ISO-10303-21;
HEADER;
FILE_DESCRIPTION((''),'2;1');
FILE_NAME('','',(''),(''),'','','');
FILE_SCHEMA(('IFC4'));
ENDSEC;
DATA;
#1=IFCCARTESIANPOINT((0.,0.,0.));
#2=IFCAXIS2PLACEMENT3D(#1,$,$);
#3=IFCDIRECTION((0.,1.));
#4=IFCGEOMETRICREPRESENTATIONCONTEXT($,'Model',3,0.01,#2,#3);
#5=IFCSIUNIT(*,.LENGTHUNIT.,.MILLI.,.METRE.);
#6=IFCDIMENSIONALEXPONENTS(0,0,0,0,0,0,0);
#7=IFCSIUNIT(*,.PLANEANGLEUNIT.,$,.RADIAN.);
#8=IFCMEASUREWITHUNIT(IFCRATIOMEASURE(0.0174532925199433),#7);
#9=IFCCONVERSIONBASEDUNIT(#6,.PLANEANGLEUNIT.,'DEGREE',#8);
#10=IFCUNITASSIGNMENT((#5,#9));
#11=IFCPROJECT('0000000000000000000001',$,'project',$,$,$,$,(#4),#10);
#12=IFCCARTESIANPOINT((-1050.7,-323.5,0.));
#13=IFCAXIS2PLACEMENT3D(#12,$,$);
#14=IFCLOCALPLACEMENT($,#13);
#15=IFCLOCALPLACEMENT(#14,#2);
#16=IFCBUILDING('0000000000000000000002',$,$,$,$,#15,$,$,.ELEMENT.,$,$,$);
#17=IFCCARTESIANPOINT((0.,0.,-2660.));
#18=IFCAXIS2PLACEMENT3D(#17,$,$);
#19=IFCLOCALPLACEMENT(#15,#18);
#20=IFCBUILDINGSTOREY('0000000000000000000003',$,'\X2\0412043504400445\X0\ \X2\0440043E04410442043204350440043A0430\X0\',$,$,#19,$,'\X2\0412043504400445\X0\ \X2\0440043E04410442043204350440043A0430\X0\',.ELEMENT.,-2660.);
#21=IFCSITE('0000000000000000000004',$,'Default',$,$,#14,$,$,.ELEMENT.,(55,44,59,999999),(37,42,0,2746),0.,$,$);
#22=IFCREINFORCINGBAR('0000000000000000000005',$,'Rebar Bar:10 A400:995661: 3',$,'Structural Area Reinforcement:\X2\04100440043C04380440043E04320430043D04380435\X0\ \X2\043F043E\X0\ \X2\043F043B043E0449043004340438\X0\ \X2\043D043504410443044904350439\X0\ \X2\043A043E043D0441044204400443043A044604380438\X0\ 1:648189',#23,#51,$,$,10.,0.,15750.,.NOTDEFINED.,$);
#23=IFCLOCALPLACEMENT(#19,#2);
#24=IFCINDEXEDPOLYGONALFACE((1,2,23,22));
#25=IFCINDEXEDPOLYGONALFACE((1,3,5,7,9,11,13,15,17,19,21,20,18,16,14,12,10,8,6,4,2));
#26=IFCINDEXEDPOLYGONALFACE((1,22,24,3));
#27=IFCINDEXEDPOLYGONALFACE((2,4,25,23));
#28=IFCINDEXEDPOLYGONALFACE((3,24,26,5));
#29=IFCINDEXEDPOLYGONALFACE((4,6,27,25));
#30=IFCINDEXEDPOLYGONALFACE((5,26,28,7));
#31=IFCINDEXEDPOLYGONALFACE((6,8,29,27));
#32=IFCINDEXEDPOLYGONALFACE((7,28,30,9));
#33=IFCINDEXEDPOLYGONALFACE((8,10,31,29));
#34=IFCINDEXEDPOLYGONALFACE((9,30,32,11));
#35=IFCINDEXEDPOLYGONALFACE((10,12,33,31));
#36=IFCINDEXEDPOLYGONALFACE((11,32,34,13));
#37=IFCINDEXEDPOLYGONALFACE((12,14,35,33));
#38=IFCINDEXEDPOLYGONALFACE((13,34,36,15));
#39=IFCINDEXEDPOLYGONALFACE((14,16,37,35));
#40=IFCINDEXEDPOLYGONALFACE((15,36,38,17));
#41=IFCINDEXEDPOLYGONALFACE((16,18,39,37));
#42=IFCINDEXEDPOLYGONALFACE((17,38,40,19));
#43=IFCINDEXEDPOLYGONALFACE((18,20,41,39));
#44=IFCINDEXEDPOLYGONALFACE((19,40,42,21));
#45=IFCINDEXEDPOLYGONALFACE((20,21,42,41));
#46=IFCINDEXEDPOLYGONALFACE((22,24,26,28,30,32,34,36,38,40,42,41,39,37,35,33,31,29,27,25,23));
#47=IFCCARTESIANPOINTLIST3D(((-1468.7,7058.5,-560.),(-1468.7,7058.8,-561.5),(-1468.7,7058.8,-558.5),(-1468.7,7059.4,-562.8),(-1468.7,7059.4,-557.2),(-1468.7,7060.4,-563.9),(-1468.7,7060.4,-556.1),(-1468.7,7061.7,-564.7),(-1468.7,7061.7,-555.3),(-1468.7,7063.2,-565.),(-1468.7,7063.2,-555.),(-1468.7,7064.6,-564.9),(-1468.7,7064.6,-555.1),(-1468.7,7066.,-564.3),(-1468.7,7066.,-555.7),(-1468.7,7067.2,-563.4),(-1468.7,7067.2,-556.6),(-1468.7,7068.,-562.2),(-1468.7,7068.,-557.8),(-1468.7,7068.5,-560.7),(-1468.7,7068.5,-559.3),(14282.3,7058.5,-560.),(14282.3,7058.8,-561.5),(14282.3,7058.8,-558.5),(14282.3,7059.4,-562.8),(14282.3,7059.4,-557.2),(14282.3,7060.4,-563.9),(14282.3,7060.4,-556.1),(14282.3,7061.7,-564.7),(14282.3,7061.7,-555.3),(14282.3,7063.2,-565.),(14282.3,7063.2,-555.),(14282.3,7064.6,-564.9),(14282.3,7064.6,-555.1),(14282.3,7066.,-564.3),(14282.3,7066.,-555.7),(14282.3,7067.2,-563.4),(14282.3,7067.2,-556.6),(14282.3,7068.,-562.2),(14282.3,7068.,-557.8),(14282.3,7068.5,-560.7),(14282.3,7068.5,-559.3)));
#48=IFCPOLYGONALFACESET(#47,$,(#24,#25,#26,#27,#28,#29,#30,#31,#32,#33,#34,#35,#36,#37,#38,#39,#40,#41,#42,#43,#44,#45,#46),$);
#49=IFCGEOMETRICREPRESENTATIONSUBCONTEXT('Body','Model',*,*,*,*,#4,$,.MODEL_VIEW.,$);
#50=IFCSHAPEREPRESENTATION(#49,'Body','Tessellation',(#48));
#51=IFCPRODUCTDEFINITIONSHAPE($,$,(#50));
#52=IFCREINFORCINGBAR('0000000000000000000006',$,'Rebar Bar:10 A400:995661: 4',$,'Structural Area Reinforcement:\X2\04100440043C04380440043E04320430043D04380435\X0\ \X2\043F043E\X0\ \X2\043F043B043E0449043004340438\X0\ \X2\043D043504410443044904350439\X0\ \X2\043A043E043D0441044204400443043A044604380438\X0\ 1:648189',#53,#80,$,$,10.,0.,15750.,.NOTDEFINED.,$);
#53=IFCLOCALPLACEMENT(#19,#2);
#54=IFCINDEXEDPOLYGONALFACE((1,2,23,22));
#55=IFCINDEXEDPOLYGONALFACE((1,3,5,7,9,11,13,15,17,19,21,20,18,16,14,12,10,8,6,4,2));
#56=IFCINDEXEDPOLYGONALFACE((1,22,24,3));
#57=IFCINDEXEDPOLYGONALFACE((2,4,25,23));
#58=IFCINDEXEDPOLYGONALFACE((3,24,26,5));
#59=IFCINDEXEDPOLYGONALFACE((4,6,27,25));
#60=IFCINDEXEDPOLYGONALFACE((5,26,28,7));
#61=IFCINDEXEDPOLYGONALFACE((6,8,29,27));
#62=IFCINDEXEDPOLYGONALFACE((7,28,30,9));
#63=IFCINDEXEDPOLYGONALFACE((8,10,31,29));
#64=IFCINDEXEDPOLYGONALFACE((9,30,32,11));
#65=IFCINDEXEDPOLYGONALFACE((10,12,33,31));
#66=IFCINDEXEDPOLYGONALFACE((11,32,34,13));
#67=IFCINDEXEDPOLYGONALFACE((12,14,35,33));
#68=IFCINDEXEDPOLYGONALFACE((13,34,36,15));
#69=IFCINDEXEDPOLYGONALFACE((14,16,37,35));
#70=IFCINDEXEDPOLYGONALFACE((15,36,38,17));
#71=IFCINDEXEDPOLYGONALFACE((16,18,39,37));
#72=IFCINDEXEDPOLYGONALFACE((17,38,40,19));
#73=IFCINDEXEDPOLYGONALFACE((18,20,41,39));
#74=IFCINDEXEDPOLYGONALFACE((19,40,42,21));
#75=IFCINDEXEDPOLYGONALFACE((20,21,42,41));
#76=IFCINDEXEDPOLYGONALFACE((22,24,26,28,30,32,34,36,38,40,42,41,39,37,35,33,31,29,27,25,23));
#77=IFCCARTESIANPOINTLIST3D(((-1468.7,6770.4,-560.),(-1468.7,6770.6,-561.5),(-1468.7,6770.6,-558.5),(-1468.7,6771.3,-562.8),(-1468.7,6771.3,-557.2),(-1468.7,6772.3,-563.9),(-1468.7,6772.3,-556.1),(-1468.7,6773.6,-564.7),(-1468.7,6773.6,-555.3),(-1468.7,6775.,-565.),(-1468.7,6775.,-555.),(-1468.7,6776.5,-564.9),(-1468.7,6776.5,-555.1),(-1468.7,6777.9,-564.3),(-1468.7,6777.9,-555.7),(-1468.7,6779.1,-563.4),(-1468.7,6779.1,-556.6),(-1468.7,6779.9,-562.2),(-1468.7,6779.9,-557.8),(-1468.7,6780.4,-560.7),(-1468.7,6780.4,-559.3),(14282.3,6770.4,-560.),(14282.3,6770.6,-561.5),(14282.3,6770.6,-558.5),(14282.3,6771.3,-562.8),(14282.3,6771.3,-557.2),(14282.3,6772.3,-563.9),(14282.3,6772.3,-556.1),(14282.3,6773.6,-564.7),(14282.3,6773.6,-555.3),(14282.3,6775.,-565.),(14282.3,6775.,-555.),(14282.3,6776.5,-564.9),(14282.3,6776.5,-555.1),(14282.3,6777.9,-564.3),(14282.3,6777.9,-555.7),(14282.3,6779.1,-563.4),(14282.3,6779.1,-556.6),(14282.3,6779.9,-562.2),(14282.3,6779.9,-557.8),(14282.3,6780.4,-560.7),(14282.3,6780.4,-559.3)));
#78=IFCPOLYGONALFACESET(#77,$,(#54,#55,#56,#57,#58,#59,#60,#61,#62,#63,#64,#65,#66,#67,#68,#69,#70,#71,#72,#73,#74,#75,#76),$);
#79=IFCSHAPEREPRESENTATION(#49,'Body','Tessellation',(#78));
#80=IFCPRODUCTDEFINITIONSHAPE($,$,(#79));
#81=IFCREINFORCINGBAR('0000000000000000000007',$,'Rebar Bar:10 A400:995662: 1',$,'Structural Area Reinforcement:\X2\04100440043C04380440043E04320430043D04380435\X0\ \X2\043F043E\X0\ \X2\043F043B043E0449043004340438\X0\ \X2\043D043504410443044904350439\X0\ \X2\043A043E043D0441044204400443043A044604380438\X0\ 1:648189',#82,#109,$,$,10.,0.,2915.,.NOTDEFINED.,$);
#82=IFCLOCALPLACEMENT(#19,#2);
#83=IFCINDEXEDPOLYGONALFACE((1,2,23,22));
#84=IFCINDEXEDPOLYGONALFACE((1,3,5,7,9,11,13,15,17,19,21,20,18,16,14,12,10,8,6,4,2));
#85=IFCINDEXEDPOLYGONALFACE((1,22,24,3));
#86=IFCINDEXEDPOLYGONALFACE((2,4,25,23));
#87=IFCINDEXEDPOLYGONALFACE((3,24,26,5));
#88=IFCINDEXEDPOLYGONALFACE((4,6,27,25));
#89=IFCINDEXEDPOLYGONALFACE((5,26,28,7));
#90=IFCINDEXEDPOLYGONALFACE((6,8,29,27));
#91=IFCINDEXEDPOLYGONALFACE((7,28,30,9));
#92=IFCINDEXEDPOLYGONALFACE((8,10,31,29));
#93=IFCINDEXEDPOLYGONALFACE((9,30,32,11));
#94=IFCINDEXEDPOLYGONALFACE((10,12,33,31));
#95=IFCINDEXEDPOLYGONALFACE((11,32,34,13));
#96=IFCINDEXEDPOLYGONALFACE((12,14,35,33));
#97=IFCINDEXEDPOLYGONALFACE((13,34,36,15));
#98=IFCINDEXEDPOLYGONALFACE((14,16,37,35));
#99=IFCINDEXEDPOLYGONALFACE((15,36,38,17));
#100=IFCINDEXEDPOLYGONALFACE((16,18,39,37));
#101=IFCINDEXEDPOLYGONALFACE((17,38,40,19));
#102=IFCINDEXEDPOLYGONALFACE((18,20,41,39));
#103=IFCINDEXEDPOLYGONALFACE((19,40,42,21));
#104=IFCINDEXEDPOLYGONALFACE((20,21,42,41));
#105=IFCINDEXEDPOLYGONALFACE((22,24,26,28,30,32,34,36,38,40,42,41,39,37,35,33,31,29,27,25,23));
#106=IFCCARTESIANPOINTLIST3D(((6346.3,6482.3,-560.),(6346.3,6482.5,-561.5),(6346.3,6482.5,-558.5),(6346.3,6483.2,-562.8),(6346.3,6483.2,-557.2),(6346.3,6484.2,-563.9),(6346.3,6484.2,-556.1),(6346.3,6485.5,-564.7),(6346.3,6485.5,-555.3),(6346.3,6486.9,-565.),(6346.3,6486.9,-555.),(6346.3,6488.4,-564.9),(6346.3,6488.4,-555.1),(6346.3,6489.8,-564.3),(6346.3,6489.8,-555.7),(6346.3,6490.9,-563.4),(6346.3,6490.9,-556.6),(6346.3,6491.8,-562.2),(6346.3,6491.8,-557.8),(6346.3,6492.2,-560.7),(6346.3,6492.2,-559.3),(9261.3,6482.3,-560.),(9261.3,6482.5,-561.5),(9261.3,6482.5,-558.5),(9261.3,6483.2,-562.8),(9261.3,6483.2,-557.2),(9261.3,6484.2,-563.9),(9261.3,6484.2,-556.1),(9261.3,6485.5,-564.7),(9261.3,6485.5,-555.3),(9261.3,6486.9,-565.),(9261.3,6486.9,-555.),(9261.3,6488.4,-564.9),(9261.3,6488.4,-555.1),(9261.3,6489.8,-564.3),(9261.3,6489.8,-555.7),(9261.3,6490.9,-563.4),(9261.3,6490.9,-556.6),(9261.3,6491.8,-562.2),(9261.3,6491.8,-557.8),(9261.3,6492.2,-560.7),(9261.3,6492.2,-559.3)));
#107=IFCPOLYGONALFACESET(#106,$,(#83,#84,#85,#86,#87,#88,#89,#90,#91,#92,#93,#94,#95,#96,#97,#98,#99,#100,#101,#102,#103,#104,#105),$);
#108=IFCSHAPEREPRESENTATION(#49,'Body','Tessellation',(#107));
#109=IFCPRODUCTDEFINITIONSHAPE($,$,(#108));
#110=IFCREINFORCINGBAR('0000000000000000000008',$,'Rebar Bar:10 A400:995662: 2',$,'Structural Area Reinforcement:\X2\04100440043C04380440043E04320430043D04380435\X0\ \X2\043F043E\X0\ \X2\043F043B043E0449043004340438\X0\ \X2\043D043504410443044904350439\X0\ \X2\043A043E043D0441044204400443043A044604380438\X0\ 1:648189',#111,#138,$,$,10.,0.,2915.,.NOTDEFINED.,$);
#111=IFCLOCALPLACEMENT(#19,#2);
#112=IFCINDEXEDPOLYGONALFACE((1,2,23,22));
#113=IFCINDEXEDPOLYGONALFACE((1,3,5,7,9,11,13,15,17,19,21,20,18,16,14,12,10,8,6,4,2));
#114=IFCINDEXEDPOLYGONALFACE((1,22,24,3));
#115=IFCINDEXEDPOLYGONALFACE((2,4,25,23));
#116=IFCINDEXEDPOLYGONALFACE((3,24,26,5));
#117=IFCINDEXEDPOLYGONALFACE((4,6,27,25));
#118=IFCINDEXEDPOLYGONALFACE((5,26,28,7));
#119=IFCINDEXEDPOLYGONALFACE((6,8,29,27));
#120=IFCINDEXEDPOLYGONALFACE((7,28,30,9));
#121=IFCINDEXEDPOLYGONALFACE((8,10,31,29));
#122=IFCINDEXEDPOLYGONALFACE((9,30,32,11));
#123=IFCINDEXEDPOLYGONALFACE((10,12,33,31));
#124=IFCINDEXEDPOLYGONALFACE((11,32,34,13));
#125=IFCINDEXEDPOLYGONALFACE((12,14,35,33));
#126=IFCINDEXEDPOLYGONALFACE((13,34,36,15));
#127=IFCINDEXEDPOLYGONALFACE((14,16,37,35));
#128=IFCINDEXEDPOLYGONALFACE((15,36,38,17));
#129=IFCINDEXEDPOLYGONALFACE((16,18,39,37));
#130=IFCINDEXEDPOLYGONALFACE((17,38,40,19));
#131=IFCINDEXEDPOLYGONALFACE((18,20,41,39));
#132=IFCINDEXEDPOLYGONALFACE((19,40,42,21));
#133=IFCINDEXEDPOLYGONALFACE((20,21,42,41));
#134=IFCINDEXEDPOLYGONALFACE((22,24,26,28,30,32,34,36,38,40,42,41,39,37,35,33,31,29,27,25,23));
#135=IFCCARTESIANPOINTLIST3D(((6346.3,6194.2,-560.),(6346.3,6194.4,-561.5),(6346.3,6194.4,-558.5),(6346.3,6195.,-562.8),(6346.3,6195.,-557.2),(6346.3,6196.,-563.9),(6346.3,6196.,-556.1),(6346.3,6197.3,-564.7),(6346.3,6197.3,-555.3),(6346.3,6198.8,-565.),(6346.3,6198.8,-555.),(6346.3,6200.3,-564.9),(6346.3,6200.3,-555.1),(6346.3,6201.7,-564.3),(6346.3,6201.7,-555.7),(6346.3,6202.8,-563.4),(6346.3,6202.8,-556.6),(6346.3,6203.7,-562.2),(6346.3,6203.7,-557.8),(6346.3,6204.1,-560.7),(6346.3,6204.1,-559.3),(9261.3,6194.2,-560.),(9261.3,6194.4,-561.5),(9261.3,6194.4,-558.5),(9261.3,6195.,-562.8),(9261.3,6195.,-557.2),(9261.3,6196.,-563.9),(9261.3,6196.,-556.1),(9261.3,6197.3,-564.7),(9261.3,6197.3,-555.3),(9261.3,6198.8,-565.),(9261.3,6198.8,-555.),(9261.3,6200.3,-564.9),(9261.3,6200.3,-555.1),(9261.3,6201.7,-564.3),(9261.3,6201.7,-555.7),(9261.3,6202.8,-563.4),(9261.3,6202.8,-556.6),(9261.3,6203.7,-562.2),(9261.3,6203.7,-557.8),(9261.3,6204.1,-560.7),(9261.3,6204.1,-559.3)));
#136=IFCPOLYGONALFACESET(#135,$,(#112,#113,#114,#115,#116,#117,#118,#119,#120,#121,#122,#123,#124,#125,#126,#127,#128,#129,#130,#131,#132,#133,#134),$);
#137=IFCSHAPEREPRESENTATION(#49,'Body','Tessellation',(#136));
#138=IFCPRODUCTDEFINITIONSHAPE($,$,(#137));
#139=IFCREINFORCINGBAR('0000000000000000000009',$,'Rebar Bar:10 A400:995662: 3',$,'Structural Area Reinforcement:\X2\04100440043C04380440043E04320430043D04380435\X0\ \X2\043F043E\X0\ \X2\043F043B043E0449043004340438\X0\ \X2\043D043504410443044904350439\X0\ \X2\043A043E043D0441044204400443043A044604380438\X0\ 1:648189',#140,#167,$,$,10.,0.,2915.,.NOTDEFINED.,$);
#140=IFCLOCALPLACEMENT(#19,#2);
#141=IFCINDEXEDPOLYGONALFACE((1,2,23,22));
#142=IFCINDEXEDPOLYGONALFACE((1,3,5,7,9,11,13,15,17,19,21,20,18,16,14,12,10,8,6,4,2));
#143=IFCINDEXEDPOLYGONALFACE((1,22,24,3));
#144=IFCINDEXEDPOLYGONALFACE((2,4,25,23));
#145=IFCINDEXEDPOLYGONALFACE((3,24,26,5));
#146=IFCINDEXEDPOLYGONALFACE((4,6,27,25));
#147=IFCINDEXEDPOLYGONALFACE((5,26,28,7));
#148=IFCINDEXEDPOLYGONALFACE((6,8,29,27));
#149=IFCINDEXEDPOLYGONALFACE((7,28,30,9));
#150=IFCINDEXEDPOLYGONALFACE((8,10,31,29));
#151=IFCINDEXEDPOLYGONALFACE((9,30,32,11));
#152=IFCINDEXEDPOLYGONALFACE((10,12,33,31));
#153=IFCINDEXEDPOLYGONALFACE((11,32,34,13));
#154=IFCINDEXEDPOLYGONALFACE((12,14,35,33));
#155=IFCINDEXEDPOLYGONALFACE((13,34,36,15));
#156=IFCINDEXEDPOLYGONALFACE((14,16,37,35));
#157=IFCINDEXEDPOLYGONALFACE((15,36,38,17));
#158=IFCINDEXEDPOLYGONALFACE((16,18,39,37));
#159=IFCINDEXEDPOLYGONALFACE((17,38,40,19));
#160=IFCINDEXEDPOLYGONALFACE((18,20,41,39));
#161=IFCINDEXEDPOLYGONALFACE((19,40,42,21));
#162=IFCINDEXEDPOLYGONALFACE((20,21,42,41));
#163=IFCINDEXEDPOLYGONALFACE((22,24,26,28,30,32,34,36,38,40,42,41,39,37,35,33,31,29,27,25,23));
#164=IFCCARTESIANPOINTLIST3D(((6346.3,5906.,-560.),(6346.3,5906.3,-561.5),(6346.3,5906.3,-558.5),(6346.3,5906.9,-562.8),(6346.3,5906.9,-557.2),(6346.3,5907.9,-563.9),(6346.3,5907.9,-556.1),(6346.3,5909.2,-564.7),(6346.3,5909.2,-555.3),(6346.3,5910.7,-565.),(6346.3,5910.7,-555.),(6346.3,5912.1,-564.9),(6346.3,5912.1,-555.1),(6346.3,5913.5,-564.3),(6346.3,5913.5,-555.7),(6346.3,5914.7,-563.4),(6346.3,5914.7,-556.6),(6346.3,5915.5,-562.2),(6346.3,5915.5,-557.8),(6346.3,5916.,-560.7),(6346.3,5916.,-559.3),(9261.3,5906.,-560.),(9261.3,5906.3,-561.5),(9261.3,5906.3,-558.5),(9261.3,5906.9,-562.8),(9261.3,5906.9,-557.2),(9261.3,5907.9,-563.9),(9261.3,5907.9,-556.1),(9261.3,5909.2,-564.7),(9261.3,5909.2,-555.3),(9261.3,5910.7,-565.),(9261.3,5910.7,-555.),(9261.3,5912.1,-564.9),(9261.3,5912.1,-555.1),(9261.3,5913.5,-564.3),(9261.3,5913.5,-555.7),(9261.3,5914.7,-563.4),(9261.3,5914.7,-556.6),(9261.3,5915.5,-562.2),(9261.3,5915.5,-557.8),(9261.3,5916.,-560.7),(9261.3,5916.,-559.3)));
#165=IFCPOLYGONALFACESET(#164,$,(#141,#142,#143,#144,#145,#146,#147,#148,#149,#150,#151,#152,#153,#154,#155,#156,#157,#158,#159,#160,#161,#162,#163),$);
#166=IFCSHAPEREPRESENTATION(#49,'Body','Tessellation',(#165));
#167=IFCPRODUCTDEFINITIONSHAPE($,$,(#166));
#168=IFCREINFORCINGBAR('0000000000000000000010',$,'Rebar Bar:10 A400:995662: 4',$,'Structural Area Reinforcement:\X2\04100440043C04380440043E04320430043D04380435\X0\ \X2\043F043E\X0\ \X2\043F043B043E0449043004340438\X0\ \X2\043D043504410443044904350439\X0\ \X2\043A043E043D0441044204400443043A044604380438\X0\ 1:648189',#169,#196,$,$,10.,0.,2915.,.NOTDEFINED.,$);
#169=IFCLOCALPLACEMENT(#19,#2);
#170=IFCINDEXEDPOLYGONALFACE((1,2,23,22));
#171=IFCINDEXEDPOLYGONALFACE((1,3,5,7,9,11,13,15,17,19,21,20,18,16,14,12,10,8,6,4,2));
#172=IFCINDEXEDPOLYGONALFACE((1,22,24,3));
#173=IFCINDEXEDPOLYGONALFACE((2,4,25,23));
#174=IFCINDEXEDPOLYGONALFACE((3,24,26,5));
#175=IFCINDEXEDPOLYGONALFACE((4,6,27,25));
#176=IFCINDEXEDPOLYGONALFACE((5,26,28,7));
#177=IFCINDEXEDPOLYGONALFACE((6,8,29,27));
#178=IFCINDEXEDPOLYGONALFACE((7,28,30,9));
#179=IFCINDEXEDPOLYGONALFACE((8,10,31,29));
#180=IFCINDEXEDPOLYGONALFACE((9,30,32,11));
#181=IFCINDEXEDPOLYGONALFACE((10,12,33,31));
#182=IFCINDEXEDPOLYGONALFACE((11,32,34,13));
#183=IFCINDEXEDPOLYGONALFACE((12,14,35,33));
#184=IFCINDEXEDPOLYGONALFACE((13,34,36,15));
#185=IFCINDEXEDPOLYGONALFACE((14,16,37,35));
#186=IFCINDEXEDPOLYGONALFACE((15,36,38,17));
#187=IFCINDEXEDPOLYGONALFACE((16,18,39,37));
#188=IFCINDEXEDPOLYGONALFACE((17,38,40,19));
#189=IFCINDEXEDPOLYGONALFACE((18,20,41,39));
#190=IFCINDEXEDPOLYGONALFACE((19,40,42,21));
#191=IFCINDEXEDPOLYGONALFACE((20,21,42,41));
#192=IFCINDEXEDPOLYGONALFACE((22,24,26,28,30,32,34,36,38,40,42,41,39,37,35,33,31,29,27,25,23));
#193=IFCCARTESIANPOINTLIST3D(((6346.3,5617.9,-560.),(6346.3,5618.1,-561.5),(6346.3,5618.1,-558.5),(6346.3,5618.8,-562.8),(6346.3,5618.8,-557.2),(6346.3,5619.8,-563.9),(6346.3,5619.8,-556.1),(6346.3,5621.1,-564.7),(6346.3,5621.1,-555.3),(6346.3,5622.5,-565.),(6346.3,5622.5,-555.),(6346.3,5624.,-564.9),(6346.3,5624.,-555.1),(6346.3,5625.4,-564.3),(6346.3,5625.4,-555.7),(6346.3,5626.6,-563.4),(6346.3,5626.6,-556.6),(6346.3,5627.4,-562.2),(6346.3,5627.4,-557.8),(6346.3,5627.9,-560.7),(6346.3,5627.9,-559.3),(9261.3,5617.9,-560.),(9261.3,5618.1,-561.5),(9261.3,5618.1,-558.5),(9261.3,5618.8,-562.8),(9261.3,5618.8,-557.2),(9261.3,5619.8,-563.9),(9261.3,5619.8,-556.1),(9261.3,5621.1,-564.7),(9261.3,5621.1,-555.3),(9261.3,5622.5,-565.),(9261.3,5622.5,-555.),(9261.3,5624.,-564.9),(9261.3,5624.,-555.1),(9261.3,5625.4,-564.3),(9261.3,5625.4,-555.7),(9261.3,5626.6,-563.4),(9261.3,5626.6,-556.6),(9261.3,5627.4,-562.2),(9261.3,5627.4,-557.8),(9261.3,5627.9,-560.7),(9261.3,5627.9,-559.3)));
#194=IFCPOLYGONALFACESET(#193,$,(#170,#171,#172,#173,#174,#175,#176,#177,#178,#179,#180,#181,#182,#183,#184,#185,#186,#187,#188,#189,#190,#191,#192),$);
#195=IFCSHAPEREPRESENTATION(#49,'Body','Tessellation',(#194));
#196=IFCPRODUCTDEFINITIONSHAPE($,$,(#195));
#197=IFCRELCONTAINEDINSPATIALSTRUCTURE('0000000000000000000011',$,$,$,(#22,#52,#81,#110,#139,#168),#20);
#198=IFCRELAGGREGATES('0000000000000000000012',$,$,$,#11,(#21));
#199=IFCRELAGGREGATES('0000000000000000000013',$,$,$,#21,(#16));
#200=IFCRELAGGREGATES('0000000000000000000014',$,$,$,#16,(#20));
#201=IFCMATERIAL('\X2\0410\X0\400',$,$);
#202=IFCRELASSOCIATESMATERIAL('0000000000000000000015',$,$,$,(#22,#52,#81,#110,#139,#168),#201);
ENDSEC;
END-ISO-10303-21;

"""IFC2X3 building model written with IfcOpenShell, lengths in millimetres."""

from ifc_helpers import new_model, entity, si_unit, converted_unit, direction, frame, origin, place, context, subcontext, project, spatial, material, element, save


model = new_model("IFC2X3")

# Units and contexts
model_context = context("Model", 3, precision=0.01, world=origin(), true_north=direction((0.0, 1.0)))
body_context = subcontext(model_context, "Body", "Model", "MODEL_VIEW")
ifc_project = project(units=[si_unit("LENGTHUNIT", "METRE", prefix="MILLI"), converted_unit("PLANEANGLEUNIT", "DEGREE", entity("IfcRatioMeasure", 0.0174532925199433), si_unit("PLANEANGLEUNIT", "RADIAN"), dimensions=[0, 0, 0, 0, 0, 0, 0])], contexts=[model_context])

# Site, building, storey
site_placement = place(None, frame((-1050.7, -323.5, 0.0)))
site = spatial("IfcSite", under=ifc_project, at=site_placement, Name="Default", CompositionType="ELEMENT", RefLatitude=(55, 44, 59, 999999), RefLongitude=(37, 42, 0, 2746), RefElevation=0.0)
building_placement = place(site_placement, origin())
building = spatial("IfcBuilding", under=site, at=building_placement, CompositionType="ELEMENT")
storey_placement = place(building_placement, frame((0.0, 0.0, -2660.0)))
storey = spatial("IfcBuildingStorey", under=building, at=storey_placement, Name="Верх ростверка", LongName="Верх ростверка", CompositionType="ELEMENT", Elevation=-2660.0)

# Reinforcing bars
ifc_material = material(Name="А400")
reinforcing_bar_1_placement = place(storey_placement, origin())
element("IfcReinforcingBar", 1, at=reinforcing_bar_1_placement, inside=storey, material=ifc_material, Name="Rebar Bar:10 A400:995661: 3", ObjectType="Structural Area Reinforcement:Армирование по площади несущей конструкции 1:648189", BarLength=15750.0, BarRole="NOTDEFINED", CrossSectionArea=0.0, NominalDiameter=10.0, context=body_context, shape_type="AdvancedSweptSolid", body=[
    entity("IfcSweptDiskSolid", entity("IfcCompositeCurve", [entity("IfcCompositeCurveSegment", "CONTINUOUS", True, entity("IfcPolyline", [entity("IfcCartesianPoint", [14282.3, 7063.5, -560.0]), entity("IfcCartesianPoint", [-1468.7, 7063.5, -560.0])]))], False), 5.0, None, 0.0, 1.0),
])
reinforcing_bar_2_placement = place(storey_placement, origin())
element("IfcReinforcingBar", 2, at=reinforcing_bar_2_placement, inside=storey, material=ifc_material, Name="Rebar Bar:10 A400:995661: 4", ObjectType="Structural Area Reinforcement:Армирование по площади несущей конструкции 1:648189", BarLength=15750.0, BarRole="NOTDEFINED", CrossSectionArea=0.0, NominalDiameter=10.0, context=body_context, shape_type="AdvancedSweptSolid", body=[
    entity("IfcSweptDiskSolid", entity("IfcCompositeCurve", [entity("IfcCompositeCurveSegment", "CONTINUOUS", True, entity("IfcPolyline", [entity("IfcCartesianPoint", [14282.3, 6775.4, -560.0]), entity("IfcCartesianPoint", [-1468.7, 6775.4, -560.0])]))], False), 5.0, None, 0.0, 1.0),
])
reinforcing_bar_3_placement = place(storey_placement, origin())
element("IfcReinforcingBar", 3, at=reinforcing_bar_3_placement, inside=storey, material=ifc_material, Name="Rebar Bar:10 A400:995662: 1", ObjectType="Structural Area Reinforcement:Армирование по площади несущей конструкции 1:648189", BarLength=2915.0, BarRole="NOTDEFINED", CrossSectionArea=0.0, NominalDiameter=10.0, context=body_context, shape_type="AdvancedSweptSolid", body=[
    entity("IfcSweptDiskSolid", entity("IfcCompositeCurve", [entity("IfcCompositeCurveSegment", "CONTINUOUS", True, entity("IfcPolyline", [entity("IfcCartesianPoint", [9261.3, 6487.3, -560.0]), entity("IfcCartesianPoint", [6346.3, 6487.3, -560.0])]))], False), 5.0, None, 0.0, 1.0),
])
reinforcing_bar_4_placement = place(storey_placement, origin())
element("IfcReinforcingBar", 4, at=reinforcing_bar_4_placement, inside=storey, material=ifc_material, Name="Rebar Bar:10 A400:995662: 2", ObjectType="Structural Area Reinforcement:Армирование по площади несущей конструкции 1:648189", BarLength=2915.0, BarRole="NOTDEFINED", CrossSectionArea=0.0, NominalDiameter=10.0, context=body_context, shape_type="AdvancedSweptSolid", body=[
    entity("IfcSweptDiskSolid", entity("IfcCompositeCurve", [entity("IfcCompositeCurveSegment", "CONTINUOUS", True, entity("IfcPolyline", [entity("IfcCartesianPoint", [9261.3, 6199.2, -560.0]), entity("IfcCartesianPoint", [6346.3, 6199.2, -560.0])]))], False), 5.0, None, 0.0, 1.0),
])
reinforcing_bar_5_placement = place(storey_placement, origin())
element("IfcReinforcingBar", 5, at=reinforcing_bar_5_placement, inside=storey, material=ifc_material, Name="Rebar Bar:10 A400:995662: 3", ObjectType="Structural Area Reinforcement:Армирование по площади несущей конструкции 1:648189", BarLength=2915.0, BarRole="NOTDEFINED", CrossSectionArea=0.0, NominalDiameter=10.0, context=body_context, shape_type="AdvancedSweptSolid", body=[
    entity("IfcSweptDiskSolid", entity("IfcCompositeCurve", [entity("IfcCompositeCurveSegment", "CONTINUOUS", True, entity("IfcPolyline", [entity("IfcCartesianPoint", [9261.3, 5911.0, -560.0]), entity("IfcCartesianPoint", [6346.3, 5911.0, -560.0])]))], False), 5.0, None, 0.0, 1.0),
])
reinforcing_bar_6_placement = place(storey_placement, origin())
element("IfcReinforcingBar", 6, at=reinforcing_bar_6_placement, inside=storey, material=ifc_material, Name="Rebar Bar:10 A400:995662: 4", ObjectType="Structural Area Reinforcement:Армирование по площади несущей конструкции 1:648189", BarLength=2915.0, BarRole="NOTDEFINED", CrossSectionArea=0.0, NominalDiameter=10.0, context=body_context, shape_type="AdvancedSweptSolid", body=[
    entity("IfcSweptDiskSolid", entity("IfcCompositeCurve", [entity("IfcCompositeCurveSegment", "CONTINUOUS", True, entity("IfcPolyline", [entity("IfcCartesianPoint", [9261.3, 5622.9, -560.0]), entity("IfcCartesianPoint", [6346.3, 5622.9, -560.0])]))], False), 5.0, None, 0.0, 1.0),
])

save(model, "model.ifc")
